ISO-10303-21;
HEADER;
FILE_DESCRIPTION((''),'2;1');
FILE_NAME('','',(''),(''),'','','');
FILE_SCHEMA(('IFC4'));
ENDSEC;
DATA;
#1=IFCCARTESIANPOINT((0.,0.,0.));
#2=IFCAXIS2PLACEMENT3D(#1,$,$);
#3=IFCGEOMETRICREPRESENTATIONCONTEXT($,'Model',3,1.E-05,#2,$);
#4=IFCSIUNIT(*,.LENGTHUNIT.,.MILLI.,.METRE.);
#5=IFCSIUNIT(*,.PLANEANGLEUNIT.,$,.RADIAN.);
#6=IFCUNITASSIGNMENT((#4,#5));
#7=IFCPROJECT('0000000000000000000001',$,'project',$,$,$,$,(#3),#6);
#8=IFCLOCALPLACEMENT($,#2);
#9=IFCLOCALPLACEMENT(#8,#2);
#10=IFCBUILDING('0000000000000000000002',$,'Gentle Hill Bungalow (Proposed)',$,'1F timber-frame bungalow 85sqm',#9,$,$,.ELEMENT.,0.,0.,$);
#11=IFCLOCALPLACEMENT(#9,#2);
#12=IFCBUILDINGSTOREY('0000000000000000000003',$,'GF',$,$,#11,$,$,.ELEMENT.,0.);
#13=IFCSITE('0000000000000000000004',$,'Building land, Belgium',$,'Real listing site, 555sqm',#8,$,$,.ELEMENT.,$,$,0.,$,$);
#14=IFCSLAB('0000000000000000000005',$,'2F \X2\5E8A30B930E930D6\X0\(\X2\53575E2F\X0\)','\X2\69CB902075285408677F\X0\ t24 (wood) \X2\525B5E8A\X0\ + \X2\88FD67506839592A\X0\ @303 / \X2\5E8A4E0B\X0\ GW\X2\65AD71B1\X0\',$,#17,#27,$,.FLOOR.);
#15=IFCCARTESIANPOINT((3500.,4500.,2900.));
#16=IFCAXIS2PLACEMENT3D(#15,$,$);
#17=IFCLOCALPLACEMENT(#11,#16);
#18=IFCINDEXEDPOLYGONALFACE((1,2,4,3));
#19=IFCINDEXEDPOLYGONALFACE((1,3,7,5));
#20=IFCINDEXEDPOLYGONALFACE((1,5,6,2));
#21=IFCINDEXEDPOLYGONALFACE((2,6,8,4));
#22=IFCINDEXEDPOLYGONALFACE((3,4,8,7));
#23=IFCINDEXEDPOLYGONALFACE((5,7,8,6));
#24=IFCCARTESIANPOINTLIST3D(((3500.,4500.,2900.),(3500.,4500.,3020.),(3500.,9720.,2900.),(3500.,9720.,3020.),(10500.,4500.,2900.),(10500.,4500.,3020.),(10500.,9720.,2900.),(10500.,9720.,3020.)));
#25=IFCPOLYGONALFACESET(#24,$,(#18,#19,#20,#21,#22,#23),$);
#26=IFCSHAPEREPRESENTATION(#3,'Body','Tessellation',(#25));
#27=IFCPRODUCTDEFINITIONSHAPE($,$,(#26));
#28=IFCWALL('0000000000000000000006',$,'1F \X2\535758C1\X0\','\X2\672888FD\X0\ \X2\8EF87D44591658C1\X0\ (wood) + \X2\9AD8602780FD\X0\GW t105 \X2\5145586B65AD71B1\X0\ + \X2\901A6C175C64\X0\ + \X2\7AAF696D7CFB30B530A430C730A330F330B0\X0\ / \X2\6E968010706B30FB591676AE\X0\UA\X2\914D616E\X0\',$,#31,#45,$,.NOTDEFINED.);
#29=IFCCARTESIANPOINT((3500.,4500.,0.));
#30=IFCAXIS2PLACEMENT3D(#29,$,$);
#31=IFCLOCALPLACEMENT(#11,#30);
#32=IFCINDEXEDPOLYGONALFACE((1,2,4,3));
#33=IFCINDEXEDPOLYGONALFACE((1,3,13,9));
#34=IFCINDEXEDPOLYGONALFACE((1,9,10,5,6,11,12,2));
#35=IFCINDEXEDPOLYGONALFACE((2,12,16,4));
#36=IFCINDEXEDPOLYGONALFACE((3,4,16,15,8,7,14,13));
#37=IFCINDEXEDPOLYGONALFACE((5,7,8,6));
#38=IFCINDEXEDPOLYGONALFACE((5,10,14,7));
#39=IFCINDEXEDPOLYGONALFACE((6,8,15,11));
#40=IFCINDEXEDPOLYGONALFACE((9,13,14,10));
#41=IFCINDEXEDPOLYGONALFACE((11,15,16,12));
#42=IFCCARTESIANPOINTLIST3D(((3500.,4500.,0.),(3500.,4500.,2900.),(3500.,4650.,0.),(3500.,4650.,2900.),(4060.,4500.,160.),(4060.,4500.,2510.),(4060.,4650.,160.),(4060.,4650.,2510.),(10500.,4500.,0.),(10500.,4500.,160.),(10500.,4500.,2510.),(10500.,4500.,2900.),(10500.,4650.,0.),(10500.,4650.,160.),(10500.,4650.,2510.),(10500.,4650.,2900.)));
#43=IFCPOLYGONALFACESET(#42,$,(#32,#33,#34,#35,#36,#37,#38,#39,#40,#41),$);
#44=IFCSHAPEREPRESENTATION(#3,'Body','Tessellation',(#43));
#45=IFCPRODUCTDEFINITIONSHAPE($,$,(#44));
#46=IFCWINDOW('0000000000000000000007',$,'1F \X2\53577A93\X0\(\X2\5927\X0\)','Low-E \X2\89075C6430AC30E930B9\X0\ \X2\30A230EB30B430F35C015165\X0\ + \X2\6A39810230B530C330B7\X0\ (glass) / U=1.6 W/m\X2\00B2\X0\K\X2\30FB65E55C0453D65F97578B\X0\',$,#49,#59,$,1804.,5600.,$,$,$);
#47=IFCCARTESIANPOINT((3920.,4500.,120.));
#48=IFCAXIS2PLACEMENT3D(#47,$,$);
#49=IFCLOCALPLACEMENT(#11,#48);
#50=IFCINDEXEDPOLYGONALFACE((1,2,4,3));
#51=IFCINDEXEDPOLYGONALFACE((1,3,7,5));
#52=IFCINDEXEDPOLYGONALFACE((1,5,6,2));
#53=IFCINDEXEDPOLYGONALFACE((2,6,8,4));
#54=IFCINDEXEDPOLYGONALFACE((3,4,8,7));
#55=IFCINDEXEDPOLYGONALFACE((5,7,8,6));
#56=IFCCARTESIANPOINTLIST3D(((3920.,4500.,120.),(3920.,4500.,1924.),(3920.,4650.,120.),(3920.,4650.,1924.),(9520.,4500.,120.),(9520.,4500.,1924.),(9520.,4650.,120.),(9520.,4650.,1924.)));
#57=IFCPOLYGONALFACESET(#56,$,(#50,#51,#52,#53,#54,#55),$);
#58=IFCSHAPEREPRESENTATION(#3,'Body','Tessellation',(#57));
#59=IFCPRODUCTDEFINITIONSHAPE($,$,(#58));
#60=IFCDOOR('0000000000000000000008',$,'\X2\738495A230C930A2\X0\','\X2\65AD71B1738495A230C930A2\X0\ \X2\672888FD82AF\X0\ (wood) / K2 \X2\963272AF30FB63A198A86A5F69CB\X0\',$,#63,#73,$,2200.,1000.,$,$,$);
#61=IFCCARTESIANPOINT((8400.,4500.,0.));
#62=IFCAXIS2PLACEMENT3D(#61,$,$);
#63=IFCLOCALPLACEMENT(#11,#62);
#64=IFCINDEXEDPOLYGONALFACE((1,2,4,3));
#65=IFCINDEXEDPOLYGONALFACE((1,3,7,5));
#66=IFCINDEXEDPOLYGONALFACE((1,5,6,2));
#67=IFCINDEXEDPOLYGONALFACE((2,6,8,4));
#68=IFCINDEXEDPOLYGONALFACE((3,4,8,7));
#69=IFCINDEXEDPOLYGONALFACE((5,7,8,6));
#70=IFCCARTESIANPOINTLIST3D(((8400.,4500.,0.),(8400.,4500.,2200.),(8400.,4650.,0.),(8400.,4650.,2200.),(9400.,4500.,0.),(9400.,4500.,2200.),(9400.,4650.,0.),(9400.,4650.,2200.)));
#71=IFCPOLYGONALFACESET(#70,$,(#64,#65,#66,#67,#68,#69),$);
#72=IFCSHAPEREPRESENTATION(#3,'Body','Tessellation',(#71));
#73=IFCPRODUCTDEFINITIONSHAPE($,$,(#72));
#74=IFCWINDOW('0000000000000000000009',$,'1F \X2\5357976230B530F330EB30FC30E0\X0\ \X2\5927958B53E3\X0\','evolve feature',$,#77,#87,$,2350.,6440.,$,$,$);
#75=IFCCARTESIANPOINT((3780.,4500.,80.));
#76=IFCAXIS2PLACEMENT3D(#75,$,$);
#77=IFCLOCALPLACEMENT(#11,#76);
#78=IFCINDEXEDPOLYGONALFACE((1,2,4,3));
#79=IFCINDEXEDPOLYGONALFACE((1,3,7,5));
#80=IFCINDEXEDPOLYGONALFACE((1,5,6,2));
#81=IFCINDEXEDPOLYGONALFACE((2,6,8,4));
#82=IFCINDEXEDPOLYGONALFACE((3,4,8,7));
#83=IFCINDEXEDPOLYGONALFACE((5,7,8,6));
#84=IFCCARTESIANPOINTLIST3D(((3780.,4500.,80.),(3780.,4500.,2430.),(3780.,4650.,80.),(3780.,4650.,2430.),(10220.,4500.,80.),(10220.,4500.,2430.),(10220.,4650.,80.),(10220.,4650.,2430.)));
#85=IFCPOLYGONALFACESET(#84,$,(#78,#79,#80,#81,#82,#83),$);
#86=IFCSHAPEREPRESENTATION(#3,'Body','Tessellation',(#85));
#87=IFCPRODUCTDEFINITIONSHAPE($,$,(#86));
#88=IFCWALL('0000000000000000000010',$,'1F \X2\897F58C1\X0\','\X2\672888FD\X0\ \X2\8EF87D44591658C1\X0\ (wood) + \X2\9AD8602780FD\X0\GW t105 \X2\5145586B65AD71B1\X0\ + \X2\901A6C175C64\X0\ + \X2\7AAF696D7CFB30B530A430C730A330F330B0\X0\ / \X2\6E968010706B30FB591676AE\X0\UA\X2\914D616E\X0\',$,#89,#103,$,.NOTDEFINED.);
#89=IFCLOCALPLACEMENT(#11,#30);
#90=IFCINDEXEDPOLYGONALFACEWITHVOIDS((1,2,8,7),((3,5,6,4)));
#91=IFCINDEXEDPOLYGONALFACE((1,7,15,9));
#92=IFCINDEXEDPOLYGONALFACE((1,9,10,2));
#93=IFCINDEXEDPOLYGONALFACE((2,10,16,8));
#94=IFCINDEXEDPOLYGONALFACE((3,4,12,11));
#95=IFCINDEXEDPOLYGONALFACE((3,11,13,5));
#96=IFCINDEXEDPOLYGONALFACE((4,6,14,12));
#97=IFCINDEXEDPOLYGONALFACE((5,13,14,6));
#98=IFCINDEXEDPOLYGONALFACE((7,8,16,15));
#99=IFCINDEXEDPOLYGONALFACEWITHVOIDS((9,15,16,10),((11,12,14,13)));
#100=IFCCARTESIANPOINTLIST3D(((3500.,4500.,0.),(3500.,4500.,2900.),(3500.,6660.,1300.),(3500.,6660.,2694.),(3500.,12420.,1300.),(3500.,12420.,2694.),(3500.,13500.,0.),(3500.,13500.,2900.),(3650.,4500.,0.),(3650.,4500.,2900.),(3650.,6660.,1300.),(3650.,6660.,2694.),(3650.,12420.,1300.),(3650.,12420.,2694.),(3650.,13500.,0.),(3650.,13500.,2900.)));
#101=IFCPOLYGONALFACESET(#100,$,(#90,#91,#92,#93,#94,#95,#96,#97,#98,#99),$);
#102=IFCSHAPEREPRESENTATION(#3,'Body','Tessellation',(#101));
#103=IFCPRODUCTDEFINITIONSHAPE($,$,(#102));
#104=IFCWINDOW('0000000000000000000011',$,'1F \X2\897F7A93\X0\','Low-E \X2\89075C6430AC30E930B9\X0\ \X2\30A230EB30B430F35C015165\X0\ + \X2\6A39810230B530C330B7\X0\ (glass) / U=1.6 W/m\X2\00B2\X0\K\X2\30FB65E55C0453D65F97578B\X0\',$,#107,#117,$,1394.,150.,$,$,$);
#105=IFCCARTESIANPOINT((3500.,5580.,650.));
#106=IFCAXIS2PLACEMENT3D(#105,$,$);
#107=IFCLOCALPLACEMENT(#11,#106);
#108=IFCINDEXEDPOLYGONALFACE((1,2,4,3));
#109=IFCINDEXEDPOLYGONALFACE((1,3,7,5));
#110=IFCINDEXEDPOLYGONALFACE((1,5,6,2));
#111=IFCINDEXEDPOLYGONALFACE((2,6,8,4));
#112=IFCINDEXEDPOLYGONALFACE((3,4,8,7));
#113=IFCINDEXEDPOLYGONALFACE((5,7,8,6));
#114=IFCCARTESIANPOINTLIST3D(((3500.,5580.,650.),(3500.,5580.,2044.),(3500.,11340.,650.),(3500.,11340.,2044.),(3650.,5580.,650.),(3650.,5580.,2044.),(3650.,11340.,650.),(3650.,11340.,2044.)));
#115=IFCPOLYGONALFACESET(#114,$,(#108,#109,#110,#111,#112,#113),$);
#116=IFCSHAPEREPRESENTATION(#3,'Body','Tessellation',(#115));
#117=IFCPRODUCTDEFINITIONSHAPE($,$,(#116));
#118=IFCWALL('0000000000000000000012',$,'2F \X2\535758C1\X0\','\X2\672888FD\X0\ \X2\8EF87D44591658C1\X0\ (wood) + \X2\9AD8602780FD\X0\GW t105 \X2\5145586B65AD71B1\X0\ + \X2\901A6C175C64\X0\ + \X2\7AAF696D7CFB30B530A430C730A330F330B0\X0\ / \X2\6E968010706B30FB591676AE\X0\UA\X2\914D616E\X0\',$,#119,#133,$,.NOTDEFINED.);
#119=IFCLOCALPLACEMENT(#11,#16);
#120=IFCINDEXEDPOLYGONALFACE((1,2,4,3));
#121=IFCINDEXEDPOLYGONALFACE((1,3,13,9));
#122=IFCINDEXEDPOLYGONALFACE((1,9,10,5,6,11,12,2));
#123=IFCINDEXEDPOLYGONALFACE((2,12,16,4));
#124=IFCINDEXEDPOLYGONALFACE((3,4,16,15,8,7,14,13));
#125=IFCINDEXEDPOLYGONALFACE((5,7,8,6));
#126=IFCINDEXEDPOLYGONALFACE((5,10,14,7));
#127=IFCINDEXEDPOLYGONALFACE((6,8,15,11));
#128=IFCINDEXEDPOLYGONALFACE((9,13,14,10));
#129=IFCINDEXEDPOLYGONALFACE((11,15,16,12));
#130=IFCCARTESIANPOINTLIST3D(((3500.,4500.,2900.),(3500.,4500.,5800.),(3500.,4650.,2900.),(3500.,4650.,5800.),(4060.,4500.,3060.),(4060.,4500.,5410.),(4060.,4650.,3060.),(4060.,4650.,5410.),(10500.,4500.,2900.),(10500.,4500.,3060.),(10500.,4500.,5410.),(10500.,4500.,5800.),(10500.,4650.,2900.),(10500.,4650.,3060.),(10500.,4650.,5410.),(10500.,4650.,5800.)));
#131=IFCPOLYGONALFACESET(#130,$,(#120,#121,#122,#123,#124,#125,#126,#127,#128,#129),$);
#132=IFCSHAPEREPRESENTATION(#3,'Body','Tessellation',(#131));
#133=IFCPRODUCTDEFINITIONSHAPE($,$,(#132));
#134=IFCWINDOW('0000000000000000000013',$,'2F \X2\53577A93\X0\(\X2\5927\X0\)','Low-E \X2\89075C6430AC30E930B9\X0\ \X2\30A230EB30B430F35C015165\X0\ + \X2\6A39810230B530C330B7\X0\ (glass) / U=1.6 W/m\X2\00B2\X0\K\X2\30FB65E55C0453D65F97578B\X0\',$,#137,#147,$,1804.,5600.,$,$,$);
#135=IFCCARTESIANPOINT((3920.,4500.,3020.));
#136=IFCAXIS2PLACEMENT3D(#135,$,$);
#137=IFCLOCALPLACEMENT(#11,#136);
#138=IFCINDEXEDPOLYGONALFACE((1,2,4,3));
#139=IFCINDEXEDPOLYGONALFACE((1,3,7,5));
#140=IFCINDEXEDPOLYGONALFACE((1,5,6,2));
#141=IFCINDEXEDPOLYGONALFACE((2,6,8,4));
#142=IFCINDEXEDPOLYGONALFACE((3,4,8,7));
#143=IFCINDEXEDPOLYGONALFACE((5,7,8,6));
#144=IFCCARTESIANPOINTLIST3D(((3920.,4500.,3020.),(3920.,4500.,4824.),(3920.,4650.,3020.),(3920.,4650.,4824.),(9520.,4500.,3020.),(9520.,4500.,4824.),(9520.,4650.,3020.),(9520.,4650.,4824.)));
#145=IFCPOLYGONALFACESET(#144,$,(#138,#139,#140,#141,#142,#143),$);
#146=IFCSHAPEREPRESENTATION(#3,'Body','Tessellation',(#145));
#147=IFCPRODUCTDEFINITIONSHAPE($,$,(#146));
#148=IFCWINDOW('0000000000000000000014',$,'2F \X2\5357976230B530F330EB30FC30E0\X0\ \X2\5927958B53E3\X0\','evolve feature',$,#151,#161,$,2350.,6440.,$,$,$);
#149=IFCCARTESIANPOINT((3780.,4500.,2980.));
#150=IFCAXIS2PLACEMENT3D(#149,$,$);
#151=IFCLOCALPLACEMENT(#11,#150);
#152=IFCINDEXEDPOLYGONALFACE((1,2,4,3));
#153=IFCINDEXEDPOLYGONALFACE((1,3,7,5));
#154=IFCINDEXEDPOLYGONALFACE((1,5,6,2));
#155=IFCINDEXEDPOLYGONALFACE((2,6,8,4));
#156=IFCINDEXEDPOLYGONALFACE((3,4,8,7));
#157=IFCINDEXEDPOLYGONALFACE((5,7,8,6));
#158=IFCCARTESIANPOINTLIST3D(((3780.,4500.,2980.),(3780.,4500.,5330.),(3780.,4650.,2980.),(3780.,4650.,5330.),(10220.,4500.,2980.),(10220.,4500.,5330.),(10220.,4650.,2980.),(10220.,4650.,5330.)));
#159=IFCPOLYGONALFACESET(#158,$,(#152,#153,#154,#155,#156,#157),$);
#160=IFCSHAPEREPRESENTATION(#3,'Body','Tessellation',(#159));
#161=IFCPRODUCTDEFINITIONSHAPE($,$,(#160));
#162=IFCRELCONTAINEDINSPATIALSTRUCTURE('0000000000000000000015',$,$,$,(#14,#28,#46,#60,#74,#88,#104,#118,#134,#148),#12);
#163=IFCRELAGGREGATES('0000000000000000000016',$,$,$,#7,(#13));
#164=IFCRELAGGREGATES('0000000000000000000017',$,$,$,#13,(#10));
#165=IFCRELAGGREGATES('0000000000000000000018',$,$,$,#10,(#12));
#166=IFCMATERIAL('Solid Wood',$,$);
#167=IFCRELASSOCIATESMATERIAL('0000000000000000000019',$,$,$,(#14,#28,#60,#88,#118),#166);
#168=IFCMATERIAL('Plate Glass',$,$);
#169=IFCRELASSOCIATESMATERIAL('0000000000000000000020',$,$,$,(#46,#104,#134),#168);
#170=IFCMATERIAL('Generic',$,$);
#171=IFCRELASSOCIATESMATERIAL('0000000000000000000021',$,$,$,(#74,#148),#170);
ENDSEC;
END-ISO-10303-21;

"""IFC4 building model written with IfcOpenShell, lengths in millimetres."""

from ifc_helpers import new_model, si_unit, frame, frame_2d, origin, place, context, project, spatial, rectangle, extrude, material, element, fill, save


model = new_model("IFC4")

# Units and contexts
model_context = context("Model", 3, precision=1e-05, world=origin())
ifc_project = project(units=[si_unit("LENGTHUNIT", "METRE", prefix="MILLI"), si_unit("PLANEANGLEUNIT", "RADIAN")], contexts=[model_context])

# Site, building, storey
site_placement = place(None, origin())
site = spatial("IfcSite", under=ifc_project, at=site_placement, Name="Building land, Belgium", ObjectType="Real listing site, 555sqm", CompositionType="ELEMENT", RefElevation=0.0)
building_placement = place(site_placement, origin())
building = spatial("IfcBuilding", under=site, at=building_placement, Name="Gentle Hill Bungalow (Proposed)", ObjectType="1F timber-frame bungalow 85sqm", CompositionType="ELEMENT", ElevationOfRefHeight=0.0, ElevationOfTerrain=0.0)
storey_placement = place(building_placement, origin())
storey = spatial("IfcBuildingStorey", under=building, at=storey_placement, Name="GF", CompositionType="ELEMENT", Elevation=0.0)

# Slab
ifc_material_1 = material(Name="Solid Wood")
slab_1_placement = place(storey_placement, frame((3500.0, 4500.0, 2900.0)))
element("IfcSlab", 1, at=slab_1_placement, inside=storey, material=ifc_material_1, Name="2F 床スラブ(南帯)", Description="構造用合板 t24 (wood) 剛床 + 製材根太 @303 / 床下 GW断熱", PredefinedType="FLOOR", context=model_context, shape_type="SweptSolid", body=[
    extrude(rectangle(XDim=7000.0, YDim=5220.0, at=frame_2d((3500.0, 2610.0))), frame((3500.0, 4500.0, 2900.0)), (0.0, 0.0, 1.0), 120.0),
])
ifc_material_2 = material(Name="Generic")

# Wall, openings, windows, door
wall_1_placement = place(storey_placement, frame((3500.0, 4500.0, 0.0)))
wall_1 = element("IfcWall", 2, at=wall_1_placement, inside=storey, material=ifc_material_1, Name="1F 南壁", Description="木製 軸組外壁 (wood) + 高性能GW t105 充填断熱 + 通気層 + 窯業系サイディング / 準耐火・外皮UA配慮", PredefinedType="NOTDEFINED", context=model_context, shape_type="SweptSolid", body=[
    extrude(rectangle(XDim=7000.0, YDim=150.0, at=frame_2d((3500.0, 75.0))), frame((3500.0, 4500.0, 0.0)), (0.0, 0.0, 1.0), 2900.0),
])
opening_1_placement = place(storey_placement, frame((3920.0, 4500.0, 120.0)))
opening_1 = element("IfcOpeningElement", 3, at=opening_1_placement, cuts=wall_1, PredefinedType="NOTDEFINED", context=model_context, shape_type="SweptSolid", body=[
    extrude(rectangle(XDim=5600.0, YDim=150.0, at=frame_2d((2800.0, 75.0))), frame((3920.0, 4500.0, 120.0)), (0.0, 0.0, 1.0), 1804.0),
])
opening_2_placement = place(storey_placement, frame((8400.0, 4500.0, 0.0)))
opening_2 = element("IfcOpeningElement", 4, at=opening_2_placement, cuts=wall_1, PredefinedType="NOTDEFINED", context=model_context, shape_type="SweptSolid", body=[
    extrude(rectangle(XDim=1000.0, YDim=150.0, at=frame_2d((500.0, 75.0))), frame((8400.0, 4500.0, 0.0)), (0.0, 0.0, 1.0), 2200.0),
])
opening_3_placement = place(storey_placement, frame((3780.0, 4500.0, 80.0)))
opening_3 = element("IfcOpeningElement", 5, at=opening_3_placement, cuts=wall_1, PredefinedType="NOTDEFINED", context=model_context, shape_type="SweptSolid", body=[
    extrude(rectangle(XDim=6440.0, YDim=150.0, at=frame_2d((3220.0, 75.0))), frame((3780.0, 4500.0, 80.0)), (0.0, 0.0, 1.0), 2350.0),
])
ifc_material_3 = material(Name="Plate Glass")
window_1_placement = place(storey_placement, frame((3920.0, 4500.0, 120.0)))
window_1 = element("IfcWindow", 6, at=window_1_placement, inside=storey, material=ifc_material_3, Name="1F 南窓(大)", Description="Low-E 複層ガラス アルゴン封入 + 樹脂サッシ (glass) / U=1.6 W/m²K・日射取得型", OverallHeight=1804.0, OverallWidth=5600.0, context=model_context, shape_type="SweptSolid", body=[
    extrude(rectangle(XDim=5600.0, YDim=150.0, at=frame_2d((2800.0, 75.0))), frame((3920.0, 4500.0, 120.0)), (0.0, 0.0, 1.0), 1804.0),
])
fill(opening_1, window_1)
door_placement = place(storey_placement, frame((8400.0, 4500.0, 0.0)))
door = element("IfcDoor", 7, at=door_placement, inside=storey, material=ifc_material_1, Name="玄関ドア", Description="断熱玄関ドア 木製芯 (wood) / K2 防犯・採風機構", OverallHeight=2200.0, OverallWidth=1000.0, context=model_context, shape_type="SweptSolid", body=[
    extrude(rectangle(XDim=1000.0, YDim=150.0, at=frame_2d((500.0, 75.0))), frame((8400.0, 4500.0, 0.0)), (0.0, 0.0, 1.0), 2200.0),
])
fill(opening_2, door)
window_2_placement = place(storey_placement, frame((3780.0, 4500.0, 80.0)))
window_2 = element("IfcWindow", 8, at=window_2_placement, inside=storey, material=ifc_material_2, Name="1F 南面サンルーム 大開口", Description="evolve feature", OverallHeight=2350.0, OverallWidth=6440.0, context=model_context, shape_type="SweptSolid", body=[
    extrude(rectangle(XDim=6440.0, YDim=150.0, at=frame_2d((3220.0, 75.0))), frame((3780.0, 4500.0, 80.0)), (0.0, 0.0, 1.0), 2350.0),
])
fill(opening_3, window_2)

# Wall, opening, window
wall_2_placement = place(storey_placement, frame((3500.0, 4500.0, 0.0)))
wall_2 = element("IfcWall", 9, at=wall_2_placement, inside=storey, material=ifc_material_1, Name="1F 西壁", Description="木製 軸組外壁 (wood) + 高性能GW t105 充填断熱 + 通気層 + 窯業系サイディング / 準耐火・外皮UA配慮", PredefinedType="NOTDEFINED", context=model_context, shape_type="SweptSolid", body=[
    extrude(rectangle(XDim=150.0, YDim=9000.0, at=frame_2d((75.0, 4500.0))), frame((3500.0, 4500.0, 0.0)), (0.0, 0.0, 1.0), 2900.0),
])
opening_4_placement = place(storey_placement, frame((3500.0, 5580.0, 650.0)))
opening_4 = element("IfcOpeningElement", 10, at=opening_4_placement, cuts=wall_2, PredefinedType="NOTDEFINED", context=model_context, shape_type="SweptSolid", body=[
    extrude(rectangle(XDim=150.0, YDim=5760.0, at=frame_2d((75.0, 2880.0))), frame((3500.0, 5580.0, 650.0)), (0.0, 0.0, 1.0), 1394.0),
])
window_3_placement = place(storey_placement, frame((3500.0, 5580.0, 650.0)))
window_3 = element("IfcWindow", 11, at=window_3_placement, inside=storey, material=ifc_material_3, Name="1F 西窓", Description="Low-E 複層ガラス アルゴン封入 + 樹脂サッシ (glass) / U=1.6 W/m²K・日射取得型", OverallHeight=1394.0, OverallWidth=150.0, context=model_context, shape_type="SweptSolid", body=[
    extrude(rectangle(XDim=150.0, YDim=5760.0, at=frame_2d((75.0, 2880.0))), frame((3500.0, 5580.0, 650.0)), (0.0, 0.0, 1.0), 1394.0),
])
fill(opening_4, window_3)

# Wall, openings, windows
wall_3_placement = place(storey_placement, frame((3500.0, 4500.0, 2900.0)))
wall_3 = element("IfcWall", 12, at=wall_3_placement, inside=storey, material=ifc_material_1, Name="2F 南壁", Description="木製 軸組外壁 (wood) + 高性能GW t105 充填断熱 + 通気層 + 窯業系サイディング / 準耐火・外皮UA配慮", PredefinedType="NOTDEFINED", context=model_context, shape_type="SweptSolid", body=[
    extrude(rectangle(XDim=7000.0, YDim=150.0, at=frame_2d((3500.0, 75.0))), frame((3500.0, 4500.0, 2900.0)), (0.0, 0.0, 1.0), 2900.0),
])
opening_5_placement = place(storey_placement, frame((3920.0, 4500.0, 3020.0)))
opening_5 = element("IfcOpeningElement", 13, at=opening_5_placement, cuts=wall_3, PredefinedType="NOTDEFINED", context=model_context, shape_type="SweptSolid", body=[
    extrude(rectangle(XDim=5600.0, YDim=150.0, at=frame_2d((2800.0, 75.0))), frame((3920.0, 4500.0, 3020.0)), (0.0, 0.0, 1.0), 1804.0),
])
opening_6_placement = place(storey_placement, frame((3780.0, 4500.0, 2980.0)))
opening_6 = element("IfcOpeningElement", 14, at=opening_6_placement, cuts=wall_3, PredefinedType="NOTDEFINED", context=model_context, shape_type="SweptSolid", body=[
    extrude(rectangle(XDim=6440.0, YDim=150.0, at=frame_2d((3220.0, 75.0))), frame((3780.0, 4500.0, 2980.0)), (0.0, 0.0, 1.0), 2350.0),
])
window_4_placement = place(storey_placement, frame((3920.0, 4500.0, 3020.0)))
window_4 = element("IfcWindow", 15, at=window_4_placement, inside=storey, material=ifc_material_3, Name="2F 南窓(大)", Description="Low-E 複層ガラス アルゴン封入 + 樹脂サッシ (glass) / U=1.6 W/m²K・日射取得型", OverallHeight=1804.0, OverallWidth=5600.0, context=model_context, shape_type="SweptSolid", body=[
    extrude(rectangle(XDim=5600.0, YDim=150.0, at=frame_2d((2800.0, 75.0))), frame((3920.0, 4500.0, 3020.0)), (0.0, 0.0, 1.0), 1804.0),
])
fill(opening_5, window_4)
window_5_placement = place(storey_placement, frame((3780.0, 4500.0, 2980.0)))
window_5 = element("IfcWindow", 16, at=window_5_placement, inside=storey, material=ifc_material_2, Name="2F 南面サンルーム 大開口", Description="evolve feature", OverallHeight=2350.0, OverallWidth=6440.0, context=model_context, shape_type="SweptSolid", body=[
    extrude(rectangle(XDim=6440.0, YDim=150.0, at=frame_2d((3220.0, 75.0))), frame((3780.0, 4500.0, 2980.0)), (0.0, 0.0, 1.0), 2350.0),
])
fill(opening_6, window_5)

save(model, "model.ifc")
